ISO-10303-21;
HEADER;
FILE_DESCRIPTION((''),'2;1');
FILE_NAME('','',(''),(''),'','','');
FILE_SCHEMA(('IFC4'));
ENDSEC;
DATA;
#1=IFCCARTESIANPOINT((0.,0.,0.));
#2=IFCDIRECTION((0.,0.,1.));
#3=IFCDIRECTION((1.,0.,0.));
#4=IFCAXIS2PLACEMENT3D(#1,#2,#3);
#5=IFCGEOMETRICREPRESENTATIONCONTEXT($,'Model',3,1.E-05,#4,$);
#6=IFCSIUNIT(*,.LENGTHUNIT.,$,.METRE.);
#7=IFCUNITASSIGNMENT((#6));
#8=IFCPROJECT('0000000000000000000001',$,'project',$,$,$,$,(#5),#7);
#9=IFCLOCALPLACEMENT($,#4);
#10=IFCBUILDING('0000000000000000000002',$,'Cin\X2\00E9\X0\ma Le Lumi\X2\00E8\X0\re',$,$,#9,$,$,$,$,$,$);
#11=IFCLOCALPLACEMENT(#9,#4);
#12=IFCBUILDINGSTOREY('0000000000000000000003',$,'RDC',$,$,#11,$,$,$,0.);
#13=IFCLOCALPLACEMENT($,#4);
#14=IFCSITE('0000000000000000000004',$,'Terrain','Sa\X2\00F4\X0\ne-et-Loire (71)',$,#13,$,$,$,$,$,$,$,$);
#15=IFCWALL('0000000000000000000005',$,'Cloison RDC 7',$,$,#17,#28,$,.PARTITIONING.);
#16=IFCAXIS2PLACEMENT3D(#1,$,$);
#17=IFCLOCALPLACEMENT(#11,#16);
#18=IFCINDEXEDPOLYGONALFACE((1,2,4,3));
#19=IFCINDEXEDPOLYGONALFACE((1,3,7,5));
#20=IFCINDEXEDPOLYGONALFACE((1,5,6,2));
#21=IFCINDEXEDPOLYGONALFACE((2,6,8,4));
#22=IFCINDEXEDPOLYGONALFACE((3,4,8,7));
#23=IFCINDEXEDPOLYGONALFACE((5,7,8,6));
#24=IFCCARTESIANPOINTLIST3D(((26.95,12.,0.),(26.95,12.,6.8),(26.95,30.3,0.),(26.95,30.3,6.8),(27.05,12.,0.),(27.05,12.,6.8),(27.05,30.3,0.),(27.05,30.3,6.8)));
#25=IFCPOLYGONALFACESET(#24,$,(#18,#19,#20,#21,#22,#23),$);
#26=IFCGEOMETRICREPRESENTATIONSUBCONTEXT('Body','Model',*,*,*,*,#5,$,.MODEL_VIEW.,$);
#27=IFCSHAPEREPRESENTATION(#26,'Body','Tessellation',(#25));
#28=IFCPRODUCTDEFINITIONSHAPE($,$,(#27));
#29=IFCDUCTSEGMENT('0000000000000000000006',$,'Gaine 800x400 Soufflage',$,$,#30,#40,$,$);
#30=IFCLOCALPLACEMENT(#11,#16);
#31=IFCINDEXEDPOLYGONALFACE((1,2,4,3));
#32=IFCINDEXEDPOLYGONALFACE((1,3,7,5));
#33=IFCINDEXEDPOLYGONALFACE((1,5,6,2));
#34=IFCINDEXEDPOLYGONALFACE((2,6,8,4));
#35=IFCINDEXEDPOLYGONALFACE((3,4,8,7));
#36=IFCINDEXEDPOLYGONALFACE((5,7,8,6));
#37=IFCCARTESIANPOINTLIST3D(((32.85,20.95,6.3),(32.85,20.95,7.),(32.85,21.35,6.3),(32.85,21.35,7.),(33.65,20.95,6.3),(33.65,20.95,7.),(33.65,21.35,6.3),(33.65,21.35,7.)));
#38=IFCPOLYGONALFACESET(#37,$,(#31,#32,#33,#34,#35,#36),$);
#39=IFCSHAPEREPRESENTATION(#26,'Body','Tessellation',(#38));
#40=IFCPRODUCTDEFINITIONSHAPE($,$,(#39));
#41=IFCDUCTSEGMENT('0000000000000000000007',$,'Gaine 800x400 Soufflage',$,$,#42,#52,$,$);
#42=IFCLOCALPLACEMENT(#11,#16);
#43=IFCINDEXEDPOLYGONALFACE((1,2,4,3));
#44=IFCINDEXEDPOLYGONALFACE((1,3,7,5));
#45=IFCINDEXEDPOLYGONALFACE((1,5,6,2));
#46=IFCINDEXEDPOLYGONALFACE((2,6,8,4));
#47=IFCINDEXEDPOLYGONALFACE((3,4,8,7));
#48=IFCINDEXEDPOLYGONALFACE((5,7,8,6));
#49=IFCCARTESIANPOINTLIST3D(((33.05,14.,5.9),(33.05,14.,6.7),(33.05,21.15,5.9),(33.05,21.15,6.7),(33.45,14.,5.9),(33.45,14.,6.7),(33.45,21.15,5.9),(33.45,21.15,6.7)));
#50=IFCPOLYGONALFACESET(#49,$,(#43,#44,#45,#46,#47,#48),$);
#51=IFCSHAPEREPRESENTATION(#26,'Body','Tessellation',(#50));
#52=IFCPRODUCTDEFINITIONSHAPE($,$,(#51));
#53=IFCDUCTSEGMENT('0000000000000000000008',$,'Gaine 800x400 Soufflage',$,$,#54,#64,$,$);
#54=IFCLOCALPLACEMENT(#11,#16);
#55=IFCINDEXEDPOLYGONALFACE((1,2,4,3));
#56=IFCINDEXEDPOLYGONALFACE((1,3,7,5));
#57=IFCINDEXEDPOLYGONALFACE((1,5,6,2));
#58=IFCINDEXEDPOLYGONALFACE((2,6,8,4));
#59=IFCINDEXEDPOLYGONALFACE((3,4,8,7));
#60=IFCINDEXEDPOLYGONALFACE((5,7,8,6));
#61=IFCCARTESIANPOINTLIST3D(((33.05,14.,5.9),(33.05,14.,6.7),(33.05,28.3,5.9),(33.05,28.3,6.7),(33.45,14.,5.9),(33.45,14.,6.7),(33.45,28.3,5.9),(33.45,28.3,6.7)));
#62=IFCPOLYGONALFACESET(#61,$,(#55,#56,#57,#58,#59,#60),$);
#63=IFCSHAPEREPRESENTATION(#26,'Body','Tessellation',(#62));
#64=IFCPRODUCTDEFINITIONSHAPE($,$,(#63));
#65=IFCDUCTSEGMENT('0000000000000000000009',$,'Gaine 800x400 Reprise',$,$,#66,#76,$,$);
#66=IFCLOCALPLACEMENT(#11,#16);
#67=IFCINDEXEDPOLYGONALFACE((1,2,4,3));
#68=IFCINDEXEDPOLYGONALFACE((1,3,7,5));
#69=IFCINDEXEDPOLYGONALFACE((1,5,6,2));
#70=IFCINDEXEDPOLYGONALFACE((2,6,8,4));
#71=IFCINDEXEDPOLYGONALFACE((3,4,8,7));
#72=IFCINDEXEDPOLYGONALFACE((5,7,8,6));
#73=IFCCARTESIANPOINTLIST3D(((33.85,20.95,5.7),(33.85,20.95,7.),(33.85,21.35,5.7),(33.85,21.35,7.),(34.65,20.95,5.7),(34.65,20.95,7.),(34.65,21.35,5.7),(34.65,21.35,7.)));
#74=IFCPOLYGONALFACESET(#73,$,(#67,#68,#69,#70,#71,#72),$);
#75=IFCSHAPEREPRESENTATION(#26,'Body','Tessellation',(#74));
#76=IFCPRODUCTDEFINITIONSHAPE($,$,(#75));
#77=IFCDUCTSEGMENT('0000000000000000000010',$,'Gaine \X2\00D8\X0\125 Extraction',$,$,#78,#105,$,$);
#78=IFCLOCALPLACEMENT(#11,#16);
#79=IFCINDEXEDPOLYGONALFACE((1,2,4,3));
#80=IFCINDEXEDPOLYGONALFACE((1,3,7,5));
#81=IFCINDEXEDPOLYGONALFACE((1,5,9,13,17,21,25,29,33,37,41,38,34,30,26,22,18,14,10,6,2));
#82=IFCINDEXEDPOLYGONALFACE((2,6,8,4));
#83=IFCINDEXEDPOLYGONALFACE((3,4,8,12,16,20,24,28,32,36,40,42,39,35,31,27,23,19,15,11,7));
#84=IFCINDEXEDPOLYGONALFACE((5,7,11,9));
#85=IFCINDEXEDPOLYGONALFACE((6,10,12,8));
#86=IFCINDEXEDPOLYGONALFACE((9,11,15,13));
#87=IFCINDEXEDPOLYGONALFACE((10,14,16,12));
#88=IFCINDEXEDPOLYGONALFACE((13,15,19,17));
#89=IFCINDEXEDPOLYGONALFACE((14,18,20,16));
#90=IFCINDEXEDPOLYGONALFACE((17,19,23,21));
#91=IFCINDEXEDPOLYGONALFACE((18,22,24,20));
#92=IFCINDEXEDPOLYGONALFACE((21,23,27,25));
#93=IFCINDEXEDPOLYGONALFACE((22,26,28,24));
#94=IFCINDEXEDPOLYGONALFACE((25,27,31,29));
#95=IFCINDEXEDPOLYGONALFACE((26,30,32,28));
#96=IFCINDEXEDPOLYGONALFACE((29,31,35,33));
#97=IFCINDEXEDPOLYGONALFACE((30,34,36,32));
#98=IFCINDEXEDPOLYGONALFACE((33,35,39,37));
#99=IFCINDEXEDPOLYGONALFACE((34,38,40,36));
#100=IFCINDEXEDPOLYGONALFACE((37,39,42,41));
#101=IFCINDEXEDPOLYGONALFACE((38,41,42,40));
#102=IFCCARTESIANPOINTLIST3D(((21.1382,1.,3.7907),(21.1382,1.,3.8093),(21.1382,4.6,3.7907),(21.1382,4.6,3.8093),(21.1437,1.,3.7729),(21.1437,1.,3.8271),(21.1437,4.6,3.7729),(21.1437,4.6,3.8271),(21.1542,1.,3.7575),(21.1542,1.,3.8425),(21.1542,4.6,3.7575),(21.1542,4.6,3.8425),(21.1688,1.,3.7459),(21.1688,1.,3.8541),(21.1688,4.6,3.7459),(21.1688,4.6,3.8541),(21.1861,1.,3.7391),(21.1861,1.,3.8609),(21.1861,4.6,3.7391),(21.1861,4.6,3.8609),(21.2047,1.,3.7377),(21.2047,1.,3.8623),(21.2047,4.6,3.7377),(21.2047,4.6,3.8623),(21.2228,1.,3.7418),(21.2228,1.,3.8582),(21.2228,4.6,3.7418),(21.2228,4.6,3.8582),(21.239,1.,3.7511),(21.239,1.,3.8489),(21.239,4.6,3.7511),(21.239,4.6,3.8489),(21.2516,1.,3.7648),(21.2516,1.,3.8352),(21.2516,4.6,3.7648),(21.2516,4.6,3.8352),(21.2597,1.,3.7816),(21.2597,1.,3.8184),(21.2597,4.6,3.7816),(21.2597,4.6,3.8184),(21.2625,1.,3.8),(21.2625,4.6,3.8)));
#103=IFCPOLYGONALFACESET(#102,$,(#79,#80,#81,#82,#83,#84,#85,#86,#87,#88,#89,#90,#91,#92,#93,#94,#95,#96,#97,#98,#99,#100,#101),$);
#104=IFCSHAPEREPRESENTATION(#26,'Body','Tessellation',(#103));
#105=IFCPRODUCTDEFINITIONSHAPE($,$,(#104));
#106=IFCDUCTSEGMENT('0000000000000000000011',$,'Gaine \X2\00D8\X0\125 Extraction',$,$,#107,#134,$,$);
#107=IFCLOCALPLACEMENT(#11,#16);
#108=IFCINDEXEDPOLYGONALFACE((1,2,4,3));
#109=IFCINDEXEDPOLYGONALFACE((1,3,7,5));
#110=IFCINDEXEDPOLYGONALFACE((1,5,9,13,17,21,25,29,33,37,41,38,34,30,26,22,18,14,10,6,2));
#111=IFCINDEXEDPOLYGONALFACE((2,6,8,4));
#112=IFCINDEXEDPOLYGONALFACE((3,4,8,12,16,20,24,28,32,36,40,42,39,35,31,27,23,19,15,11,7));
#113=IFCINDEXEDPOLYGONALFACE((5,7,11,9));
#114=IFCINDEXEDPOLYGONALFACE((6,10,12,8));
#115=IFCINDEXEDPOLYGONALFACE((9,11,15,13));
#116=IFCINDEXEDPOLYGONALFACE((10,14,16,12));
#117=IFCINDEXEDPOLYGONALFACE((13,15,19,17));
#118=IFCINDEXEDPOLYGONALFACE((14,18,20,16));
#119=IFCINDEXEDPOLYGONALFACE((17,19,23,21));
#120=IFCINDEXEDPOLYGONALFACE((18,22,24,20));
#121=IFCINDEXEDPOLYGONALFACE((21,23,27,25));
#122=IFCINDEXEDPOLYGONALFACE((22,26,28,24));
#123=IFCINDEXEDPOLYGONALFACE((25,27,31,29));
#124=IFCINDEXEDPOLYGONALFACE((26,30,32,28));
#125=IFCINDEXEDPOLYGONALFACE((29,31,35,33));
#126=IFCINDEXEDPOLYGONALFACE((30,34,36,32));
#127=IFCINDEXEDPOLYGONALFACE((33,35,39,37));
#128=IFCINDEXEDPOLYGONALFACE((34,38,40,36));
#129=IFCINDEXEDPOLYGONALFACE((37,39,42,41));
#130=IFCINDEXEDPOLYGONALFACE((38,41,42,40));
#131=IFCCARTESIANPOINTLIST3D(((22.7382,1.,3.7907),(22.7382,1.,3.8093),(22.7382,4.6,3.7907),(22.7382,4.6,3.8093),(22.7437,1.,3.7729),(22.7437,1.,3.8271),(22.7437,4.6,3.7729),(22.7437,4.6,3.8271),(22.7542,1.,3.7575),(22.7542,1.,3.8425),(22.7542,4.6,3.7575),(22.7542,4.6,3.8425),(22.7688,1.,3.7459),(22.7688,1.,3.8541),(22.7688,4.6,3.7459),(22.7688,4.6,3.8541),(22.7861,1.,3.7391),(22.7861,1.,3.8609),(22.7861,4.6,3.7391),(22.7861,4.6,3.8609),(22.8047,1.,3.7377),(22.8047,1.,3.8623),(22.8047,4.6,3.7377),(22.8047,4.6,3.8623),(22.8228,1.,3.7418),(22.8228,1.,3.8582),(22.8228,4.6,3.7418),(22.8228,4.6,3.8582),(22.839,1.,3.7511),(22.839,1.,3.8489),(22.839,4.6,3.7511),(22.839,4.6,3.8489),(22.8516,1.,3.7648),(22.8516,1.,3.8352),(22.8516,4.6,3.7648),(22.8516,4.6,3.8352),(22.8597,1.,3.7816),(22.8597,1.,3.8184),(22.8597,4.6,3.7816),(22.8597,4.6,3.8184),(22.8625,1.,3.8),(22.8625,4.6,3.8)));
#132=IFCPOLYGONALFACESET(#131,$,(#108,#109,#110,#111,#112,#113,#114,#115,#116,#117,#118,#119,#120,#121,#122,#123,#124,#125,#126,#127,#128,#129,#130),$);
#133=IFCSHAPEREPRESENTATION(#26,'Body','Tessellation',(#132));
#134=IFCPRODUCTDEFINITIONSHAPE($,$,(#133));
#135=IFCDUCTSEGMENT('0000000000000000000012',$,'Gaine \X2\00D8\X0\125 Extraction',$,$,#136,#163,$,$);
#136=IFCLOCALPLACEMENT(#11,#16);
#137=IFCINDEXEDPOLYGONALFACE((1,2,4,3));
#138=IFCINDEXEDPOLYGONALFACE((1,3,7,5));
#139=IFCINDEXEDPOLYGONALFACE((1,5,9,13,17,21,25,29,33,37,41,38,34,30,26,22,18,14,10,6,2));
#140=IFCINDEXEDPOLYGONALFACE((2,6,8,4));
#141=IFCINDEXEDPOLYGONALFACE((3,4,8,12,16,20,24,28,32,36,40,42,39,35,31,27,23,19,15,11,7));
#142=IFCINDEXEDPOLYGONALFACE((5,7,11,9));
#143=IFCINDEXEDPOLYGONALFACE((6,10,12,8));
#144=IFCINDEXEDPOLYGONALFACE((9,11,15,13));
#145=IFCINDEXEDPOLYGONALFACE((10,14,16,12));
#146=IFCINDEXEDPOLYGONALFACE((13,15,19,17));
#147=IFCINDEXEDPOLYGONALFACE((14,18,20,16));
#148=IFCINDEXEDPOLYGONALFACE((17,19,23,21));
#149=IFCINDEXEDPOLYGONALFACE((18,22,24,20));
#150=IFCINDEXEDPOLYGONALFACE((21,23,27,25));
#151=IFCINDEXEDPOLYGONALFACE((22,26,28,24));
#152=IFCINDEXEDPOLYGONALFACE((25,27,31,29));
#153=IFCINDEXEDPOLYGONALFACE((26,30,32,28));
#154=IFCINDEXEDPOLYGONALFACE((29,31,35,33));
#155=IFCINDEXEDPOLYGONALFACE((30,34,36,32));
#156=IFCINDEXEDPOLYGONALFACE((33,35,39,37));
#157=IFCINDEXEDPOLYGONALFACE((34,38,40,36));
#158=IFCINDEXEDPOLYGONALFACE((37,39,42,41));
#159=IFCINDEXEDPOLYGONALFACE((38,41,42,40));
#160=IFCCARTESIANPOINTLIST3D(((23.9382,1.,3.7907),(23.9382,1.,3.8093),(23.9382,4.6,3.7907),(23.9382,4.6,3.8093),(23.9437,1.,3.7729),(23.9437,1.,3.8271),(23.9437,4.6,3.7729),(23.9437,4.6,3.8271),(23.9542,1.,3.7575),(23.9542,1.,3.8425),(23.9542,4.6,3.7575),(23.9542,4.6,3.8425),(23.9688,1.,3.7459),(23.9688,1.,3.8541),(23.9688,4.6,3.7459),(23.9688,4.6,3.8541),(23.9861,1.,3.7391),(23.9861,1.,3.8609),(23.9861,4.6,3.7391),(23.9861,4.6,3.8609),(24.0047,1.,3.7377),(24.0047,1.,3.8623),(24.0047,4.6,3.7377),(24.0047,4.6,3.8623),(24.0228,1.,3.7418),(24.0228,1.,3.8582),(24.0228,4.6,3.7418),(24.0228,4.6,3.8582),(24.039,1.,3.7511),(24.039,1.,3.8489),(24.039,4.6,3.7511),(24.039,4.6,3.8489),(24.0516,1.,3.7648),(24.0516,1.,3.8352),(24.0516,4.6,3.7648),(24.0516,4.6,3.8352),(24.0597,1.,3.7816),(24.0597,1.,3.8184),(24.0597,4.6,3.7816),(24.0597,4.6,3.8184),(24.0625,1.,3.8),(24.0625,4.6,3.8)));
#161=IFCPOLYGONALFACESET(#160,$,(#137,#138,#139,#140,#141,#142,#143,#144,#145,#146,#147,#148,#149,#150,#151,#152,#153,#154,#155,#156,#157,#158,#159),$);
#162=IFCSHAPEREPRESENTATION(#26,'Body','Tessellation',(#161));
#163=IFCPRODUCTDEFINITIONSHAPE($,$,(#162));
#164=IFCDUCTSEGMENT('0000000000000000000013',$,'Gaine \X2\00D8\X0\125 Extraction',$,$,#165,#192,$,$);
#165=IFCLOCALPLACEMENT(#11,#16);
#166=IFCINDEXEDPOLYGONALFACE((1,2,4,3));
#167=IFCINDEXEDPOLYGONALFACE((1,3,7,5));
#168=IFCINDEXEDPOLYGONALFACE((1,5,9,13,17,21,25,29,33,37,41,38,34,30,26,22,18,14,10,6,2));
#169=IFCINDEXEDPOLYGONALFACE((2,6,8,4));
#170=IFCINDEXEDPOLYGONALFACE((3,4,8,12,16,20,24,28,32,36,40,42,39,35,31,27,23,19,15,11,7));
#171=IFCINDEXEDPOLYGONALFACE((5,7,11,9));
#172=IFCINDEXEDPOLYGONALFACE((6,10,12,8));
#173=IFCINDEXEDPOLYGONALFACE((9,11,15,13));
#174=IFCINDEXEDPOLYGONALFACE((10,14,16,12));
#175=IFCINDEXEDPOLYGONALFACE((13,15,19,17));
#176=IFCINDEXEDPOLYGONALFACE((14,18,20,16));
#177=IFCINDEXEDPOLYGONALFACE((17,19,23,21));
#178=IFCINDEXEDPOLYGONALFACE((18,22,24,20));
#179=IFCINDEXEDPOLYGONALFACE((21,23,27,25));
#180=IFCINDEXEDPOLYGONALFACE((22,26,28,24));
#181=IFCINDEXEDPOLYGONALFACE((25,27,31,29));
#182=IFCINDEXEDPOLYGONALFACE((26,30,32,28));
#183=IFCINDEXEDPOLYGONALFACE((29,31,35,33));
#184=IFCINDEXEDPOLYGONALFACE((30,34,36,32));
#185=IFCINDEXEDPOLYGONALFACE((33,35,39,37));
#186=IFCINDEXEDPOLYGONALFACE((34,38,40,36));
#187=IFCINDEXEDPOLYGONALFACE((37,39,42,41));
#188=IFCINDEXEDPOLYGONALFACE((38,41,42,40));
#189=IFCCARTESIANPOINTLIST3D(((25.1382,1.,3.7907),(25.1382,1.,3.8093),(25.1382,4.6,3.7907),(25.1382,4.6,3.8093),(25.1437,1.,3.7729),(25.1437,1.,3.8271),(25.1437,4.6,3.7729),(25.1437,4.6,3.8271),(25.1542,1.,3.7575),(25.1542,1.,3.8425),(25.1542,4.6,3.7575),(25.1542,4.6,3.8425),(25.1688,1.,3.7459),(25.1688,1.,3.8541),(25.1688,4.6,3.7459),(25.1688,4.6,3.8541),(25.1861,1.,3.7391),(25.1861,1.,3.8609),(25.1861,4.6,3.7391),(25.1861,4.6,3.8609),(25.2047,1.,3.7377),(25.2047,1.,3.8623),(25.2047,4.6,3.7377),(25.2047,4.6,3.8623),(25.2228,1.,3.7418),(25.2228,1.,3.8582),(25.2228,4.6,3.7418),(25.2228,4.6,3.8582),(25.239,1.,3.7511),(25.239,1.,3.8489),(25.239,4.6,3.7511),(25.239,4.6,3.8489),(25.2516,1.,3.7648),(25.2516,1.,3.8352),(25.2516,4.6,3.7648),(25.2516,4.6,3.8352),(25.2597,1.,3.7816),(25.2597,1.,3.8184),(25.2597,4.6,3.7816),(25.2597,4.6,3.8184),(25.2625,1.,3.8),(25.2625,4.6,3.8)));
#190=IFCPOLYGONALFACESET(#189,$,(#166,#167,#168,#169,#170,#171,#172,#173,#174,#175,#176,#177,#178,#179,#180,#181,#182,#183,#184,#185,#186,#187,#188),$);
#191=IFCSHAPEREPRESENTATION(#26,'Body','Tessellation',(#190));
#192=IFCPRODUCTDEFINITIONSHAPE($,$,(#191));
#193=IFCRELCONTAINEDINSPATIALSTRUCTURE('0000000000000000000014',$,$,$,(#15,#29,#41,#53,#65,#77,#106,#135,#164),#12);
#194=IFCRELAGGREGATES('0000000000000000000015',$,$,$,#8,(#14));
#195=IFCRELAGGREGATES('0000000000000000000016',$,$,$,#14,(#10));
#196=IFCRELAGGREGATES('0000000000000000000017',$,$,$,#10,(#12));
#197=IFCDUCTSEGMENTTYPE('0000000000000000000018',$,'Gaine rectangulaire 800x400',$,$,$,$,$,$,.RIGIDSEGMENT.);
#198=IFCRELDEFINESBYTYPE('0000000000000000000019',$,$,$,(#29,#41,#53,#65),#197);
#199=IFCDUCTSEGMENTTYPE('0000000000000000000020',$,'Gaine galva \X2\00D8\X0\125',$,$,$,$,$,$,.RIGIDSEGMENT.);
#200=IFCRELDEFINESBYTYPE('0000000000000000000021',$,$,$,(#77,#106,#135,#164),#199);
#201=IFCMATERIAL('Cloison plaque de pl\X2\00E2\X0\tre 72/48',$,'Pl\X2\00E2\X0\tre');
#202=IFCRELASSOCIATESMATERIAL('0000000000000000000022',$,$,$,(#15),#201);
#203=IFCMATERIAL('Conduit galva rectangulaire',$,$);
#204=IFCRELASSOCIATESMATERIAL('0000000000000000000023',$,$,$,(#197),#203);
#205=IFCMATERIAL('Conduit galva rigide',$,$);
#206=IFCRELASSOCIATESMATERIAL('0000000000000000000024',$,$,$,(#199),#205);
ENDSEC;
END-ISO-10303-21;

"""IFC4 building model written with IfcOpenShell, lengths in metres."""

from ifc_helpers import new_model, si_unit, frame, frame_2d, origin_with_axes, origin_2d, place, context, subcontext, project, spatial, rectangle, circle, extrude, material, type_object, element, save


model = new_model("IFC4")

# Units and contexts
model_context = context("Model", 3, precision=1e-05, world=origin_with_axes())
body_context = subcontext(model_context, "Body", "Model", "MODEL_VIEW")
ifc_project = project(units=[si_unit("LENGTHUNIT", "METRE")], contexts=[model_context])

# Site, building, storey
site_placement = place(None, origin_with_axes())
site = spatial("IfcSite", under=ifc_project, at=site_placement, Name="Terrain", Description="Saône-et-Loire (71)")
building_placement = place(None, origin_with_axes())
building = spatial("IfcBuilding", under=site, at=building_placement, Name="Cinéma Le Lumière")
storey_placement = place(building_placement, origin_with_axes())
storey = spatial("IfcBuildingStorey", under=building, at=storey_placement, Name="RDC", Elevation=0.0)

# Wall
ifc_material_1 = material(Name="Cloison plaque de plâtre 72/48", Category="Plâtre")
wall_placement = place(storey_placement, frame((26.95, 12.0, 0.0), z_axis=(0.0, 0.0, 1.0), x_axis=(1.0, 0.0, 0.0)))
element("IfcWall", 1, at=wall_placement, inside=storey, material=ifc_material_1, Name="Cloison RDC 7", PredefinedType="PARTITIONING", context=body_context, shape_type="SweptSolid", body=[
    extrude(rectangle(XDim=0.1, YDim=18.3, at=frame_2d((0.05, 9.15))), origin_with_axes(), (0.0, 0.0, 1.0), 6.8),
])

# Duct segments
ifc_material_2 = material(Name="Conduit galva rectangulaire")
duct_segment_type_1 = type_object("IfcDuctSegmentType", Name="Gaine rectangulaire 800x400", PredefinedType="RIGIDSEGMENT", material=ifc_material_2)
duct_segment_1_placement = place(storey_placement, frame((33.25, 21.15, 7.0), z_axis=(0.0, 0.0, -1.0), x_axis=(1.0, 0.0, 0.0)))
element("IfcDuctSegment", 2, at=duct_segment_1_placement, inside=storey, type_object=duct_segment_type_1, Name="Gaine 800x400 Soufflage", context=body_context, shape_type="SweptSolid", body=[
    extrude(rectangle(XDim=0.8, YDim=0.4, at=origin_2d()), origin_with_axes(), (0.0, 0.0, 1.0), 0.7),
])
duct_segment_2_placement = place(storey_placement, frame((33.25, 21.15, 6.3), z_axis=(0.0, -1.0, 0.0), x_axis=(0.0, 0.0, 1.0)))
element("IfcDuctSegment", 3, at=duct_segment_2_placement, inside=storey, type_object=duct_segment_type_1, Name="Gaine 800x400 Soufflage", context=body_context, shape_type="SweptSolid", body=[
    extrude(rectangle(XDim=0.8, YDim=0.4, at=origin_2d()), origin_with_axes(), (0.0, 0.0, 1.0), 7.15),
])
duct_segment_3_placement = place(storey_placement, frame((33.25, 14.0, 6.3), z_axis=(0.0, 1.0, 0.0), x_axis=(0.0, 0.0, 1.0)))
element("IfcDuctSegment", 4, at=duct_segment_3_placement, inside=storey, type_object=duct_segment_type_1, Name="Gaine 800x400 Soufflage", context=body_context, shape_type="SweptSolid", body=[
    extrude(rectangle(XDim=0.8, YDim=0.4, at=origin_2d()), origin_with_axes(), (0.0, 0.0, 1.0), 14.3),
])
duct_segment_4_placement = place(storey_placement, frame((34.25, 21.15, 7.0), z_axis=(0.0, 0.0, -1.0), x_axis=(1.0, 0.0, 0.0)))
element("IfcDuctSegment", 5, at=duct_segment_4_placement, inside=storey, type_object=duct_segment_type_1, Name="Gaine 800x400 Reprise", context=body_context, shape_type="SweptSolid", body=[
    extrude(rectangle(XDim=0.8, YDim=0.4, at=origin_2d()), origin_with_axes(), (0.0, 0.0, 1.0), 1.3),
])
ifc_material_3 = material(Name="Conduit galva rigide")
duct_segment_type_2 = type_object("IfcDuctSegmentType", Name="Gaine galva Ø125", PredefinedType="RIGIDSEGMENT", material=ifc_material_3)
for number, where, z_axis, x_axis, name in (
    (6, (21.2, 4.6, 3.8), (0.0, -1.0, 0.0), (1.0, 0.0, 0.0), "Gaine Ø125 Extraction"),
    (7, (22.8, 4.6, 3.8), (0.0, -1.0, 0.0), (1.0, 0.0, 0.0), "Gaine Ø125 Extraction"),
    (8, (24.0, 4.6, 3.8), (0.0, -1.0, 0.0), (1.0, 0.0, 0.0), "Gaine Ø125 Extraction"),
    (9, (25.2, 4.6, 3.8), (0.0, -1.0, 0.0), (1.0, 0.0, 0.0), "Gaine Ø125 Extraction"),
):
    element("IfcDuctSegment", number, at=place(storey_placement, frame(where, z_axis=z_axis, x_axis=x_axis)), inside=storey, type_object=duct_segment_type_2, Name=name, context=body_context, shape_type="SweptSolid", body=[
        extrude(circle(Radius=0.0625), origin_with_axes(), (0.0, 0.0, 1.0), 3.6),
    ])

save(model, "model.ifc")
